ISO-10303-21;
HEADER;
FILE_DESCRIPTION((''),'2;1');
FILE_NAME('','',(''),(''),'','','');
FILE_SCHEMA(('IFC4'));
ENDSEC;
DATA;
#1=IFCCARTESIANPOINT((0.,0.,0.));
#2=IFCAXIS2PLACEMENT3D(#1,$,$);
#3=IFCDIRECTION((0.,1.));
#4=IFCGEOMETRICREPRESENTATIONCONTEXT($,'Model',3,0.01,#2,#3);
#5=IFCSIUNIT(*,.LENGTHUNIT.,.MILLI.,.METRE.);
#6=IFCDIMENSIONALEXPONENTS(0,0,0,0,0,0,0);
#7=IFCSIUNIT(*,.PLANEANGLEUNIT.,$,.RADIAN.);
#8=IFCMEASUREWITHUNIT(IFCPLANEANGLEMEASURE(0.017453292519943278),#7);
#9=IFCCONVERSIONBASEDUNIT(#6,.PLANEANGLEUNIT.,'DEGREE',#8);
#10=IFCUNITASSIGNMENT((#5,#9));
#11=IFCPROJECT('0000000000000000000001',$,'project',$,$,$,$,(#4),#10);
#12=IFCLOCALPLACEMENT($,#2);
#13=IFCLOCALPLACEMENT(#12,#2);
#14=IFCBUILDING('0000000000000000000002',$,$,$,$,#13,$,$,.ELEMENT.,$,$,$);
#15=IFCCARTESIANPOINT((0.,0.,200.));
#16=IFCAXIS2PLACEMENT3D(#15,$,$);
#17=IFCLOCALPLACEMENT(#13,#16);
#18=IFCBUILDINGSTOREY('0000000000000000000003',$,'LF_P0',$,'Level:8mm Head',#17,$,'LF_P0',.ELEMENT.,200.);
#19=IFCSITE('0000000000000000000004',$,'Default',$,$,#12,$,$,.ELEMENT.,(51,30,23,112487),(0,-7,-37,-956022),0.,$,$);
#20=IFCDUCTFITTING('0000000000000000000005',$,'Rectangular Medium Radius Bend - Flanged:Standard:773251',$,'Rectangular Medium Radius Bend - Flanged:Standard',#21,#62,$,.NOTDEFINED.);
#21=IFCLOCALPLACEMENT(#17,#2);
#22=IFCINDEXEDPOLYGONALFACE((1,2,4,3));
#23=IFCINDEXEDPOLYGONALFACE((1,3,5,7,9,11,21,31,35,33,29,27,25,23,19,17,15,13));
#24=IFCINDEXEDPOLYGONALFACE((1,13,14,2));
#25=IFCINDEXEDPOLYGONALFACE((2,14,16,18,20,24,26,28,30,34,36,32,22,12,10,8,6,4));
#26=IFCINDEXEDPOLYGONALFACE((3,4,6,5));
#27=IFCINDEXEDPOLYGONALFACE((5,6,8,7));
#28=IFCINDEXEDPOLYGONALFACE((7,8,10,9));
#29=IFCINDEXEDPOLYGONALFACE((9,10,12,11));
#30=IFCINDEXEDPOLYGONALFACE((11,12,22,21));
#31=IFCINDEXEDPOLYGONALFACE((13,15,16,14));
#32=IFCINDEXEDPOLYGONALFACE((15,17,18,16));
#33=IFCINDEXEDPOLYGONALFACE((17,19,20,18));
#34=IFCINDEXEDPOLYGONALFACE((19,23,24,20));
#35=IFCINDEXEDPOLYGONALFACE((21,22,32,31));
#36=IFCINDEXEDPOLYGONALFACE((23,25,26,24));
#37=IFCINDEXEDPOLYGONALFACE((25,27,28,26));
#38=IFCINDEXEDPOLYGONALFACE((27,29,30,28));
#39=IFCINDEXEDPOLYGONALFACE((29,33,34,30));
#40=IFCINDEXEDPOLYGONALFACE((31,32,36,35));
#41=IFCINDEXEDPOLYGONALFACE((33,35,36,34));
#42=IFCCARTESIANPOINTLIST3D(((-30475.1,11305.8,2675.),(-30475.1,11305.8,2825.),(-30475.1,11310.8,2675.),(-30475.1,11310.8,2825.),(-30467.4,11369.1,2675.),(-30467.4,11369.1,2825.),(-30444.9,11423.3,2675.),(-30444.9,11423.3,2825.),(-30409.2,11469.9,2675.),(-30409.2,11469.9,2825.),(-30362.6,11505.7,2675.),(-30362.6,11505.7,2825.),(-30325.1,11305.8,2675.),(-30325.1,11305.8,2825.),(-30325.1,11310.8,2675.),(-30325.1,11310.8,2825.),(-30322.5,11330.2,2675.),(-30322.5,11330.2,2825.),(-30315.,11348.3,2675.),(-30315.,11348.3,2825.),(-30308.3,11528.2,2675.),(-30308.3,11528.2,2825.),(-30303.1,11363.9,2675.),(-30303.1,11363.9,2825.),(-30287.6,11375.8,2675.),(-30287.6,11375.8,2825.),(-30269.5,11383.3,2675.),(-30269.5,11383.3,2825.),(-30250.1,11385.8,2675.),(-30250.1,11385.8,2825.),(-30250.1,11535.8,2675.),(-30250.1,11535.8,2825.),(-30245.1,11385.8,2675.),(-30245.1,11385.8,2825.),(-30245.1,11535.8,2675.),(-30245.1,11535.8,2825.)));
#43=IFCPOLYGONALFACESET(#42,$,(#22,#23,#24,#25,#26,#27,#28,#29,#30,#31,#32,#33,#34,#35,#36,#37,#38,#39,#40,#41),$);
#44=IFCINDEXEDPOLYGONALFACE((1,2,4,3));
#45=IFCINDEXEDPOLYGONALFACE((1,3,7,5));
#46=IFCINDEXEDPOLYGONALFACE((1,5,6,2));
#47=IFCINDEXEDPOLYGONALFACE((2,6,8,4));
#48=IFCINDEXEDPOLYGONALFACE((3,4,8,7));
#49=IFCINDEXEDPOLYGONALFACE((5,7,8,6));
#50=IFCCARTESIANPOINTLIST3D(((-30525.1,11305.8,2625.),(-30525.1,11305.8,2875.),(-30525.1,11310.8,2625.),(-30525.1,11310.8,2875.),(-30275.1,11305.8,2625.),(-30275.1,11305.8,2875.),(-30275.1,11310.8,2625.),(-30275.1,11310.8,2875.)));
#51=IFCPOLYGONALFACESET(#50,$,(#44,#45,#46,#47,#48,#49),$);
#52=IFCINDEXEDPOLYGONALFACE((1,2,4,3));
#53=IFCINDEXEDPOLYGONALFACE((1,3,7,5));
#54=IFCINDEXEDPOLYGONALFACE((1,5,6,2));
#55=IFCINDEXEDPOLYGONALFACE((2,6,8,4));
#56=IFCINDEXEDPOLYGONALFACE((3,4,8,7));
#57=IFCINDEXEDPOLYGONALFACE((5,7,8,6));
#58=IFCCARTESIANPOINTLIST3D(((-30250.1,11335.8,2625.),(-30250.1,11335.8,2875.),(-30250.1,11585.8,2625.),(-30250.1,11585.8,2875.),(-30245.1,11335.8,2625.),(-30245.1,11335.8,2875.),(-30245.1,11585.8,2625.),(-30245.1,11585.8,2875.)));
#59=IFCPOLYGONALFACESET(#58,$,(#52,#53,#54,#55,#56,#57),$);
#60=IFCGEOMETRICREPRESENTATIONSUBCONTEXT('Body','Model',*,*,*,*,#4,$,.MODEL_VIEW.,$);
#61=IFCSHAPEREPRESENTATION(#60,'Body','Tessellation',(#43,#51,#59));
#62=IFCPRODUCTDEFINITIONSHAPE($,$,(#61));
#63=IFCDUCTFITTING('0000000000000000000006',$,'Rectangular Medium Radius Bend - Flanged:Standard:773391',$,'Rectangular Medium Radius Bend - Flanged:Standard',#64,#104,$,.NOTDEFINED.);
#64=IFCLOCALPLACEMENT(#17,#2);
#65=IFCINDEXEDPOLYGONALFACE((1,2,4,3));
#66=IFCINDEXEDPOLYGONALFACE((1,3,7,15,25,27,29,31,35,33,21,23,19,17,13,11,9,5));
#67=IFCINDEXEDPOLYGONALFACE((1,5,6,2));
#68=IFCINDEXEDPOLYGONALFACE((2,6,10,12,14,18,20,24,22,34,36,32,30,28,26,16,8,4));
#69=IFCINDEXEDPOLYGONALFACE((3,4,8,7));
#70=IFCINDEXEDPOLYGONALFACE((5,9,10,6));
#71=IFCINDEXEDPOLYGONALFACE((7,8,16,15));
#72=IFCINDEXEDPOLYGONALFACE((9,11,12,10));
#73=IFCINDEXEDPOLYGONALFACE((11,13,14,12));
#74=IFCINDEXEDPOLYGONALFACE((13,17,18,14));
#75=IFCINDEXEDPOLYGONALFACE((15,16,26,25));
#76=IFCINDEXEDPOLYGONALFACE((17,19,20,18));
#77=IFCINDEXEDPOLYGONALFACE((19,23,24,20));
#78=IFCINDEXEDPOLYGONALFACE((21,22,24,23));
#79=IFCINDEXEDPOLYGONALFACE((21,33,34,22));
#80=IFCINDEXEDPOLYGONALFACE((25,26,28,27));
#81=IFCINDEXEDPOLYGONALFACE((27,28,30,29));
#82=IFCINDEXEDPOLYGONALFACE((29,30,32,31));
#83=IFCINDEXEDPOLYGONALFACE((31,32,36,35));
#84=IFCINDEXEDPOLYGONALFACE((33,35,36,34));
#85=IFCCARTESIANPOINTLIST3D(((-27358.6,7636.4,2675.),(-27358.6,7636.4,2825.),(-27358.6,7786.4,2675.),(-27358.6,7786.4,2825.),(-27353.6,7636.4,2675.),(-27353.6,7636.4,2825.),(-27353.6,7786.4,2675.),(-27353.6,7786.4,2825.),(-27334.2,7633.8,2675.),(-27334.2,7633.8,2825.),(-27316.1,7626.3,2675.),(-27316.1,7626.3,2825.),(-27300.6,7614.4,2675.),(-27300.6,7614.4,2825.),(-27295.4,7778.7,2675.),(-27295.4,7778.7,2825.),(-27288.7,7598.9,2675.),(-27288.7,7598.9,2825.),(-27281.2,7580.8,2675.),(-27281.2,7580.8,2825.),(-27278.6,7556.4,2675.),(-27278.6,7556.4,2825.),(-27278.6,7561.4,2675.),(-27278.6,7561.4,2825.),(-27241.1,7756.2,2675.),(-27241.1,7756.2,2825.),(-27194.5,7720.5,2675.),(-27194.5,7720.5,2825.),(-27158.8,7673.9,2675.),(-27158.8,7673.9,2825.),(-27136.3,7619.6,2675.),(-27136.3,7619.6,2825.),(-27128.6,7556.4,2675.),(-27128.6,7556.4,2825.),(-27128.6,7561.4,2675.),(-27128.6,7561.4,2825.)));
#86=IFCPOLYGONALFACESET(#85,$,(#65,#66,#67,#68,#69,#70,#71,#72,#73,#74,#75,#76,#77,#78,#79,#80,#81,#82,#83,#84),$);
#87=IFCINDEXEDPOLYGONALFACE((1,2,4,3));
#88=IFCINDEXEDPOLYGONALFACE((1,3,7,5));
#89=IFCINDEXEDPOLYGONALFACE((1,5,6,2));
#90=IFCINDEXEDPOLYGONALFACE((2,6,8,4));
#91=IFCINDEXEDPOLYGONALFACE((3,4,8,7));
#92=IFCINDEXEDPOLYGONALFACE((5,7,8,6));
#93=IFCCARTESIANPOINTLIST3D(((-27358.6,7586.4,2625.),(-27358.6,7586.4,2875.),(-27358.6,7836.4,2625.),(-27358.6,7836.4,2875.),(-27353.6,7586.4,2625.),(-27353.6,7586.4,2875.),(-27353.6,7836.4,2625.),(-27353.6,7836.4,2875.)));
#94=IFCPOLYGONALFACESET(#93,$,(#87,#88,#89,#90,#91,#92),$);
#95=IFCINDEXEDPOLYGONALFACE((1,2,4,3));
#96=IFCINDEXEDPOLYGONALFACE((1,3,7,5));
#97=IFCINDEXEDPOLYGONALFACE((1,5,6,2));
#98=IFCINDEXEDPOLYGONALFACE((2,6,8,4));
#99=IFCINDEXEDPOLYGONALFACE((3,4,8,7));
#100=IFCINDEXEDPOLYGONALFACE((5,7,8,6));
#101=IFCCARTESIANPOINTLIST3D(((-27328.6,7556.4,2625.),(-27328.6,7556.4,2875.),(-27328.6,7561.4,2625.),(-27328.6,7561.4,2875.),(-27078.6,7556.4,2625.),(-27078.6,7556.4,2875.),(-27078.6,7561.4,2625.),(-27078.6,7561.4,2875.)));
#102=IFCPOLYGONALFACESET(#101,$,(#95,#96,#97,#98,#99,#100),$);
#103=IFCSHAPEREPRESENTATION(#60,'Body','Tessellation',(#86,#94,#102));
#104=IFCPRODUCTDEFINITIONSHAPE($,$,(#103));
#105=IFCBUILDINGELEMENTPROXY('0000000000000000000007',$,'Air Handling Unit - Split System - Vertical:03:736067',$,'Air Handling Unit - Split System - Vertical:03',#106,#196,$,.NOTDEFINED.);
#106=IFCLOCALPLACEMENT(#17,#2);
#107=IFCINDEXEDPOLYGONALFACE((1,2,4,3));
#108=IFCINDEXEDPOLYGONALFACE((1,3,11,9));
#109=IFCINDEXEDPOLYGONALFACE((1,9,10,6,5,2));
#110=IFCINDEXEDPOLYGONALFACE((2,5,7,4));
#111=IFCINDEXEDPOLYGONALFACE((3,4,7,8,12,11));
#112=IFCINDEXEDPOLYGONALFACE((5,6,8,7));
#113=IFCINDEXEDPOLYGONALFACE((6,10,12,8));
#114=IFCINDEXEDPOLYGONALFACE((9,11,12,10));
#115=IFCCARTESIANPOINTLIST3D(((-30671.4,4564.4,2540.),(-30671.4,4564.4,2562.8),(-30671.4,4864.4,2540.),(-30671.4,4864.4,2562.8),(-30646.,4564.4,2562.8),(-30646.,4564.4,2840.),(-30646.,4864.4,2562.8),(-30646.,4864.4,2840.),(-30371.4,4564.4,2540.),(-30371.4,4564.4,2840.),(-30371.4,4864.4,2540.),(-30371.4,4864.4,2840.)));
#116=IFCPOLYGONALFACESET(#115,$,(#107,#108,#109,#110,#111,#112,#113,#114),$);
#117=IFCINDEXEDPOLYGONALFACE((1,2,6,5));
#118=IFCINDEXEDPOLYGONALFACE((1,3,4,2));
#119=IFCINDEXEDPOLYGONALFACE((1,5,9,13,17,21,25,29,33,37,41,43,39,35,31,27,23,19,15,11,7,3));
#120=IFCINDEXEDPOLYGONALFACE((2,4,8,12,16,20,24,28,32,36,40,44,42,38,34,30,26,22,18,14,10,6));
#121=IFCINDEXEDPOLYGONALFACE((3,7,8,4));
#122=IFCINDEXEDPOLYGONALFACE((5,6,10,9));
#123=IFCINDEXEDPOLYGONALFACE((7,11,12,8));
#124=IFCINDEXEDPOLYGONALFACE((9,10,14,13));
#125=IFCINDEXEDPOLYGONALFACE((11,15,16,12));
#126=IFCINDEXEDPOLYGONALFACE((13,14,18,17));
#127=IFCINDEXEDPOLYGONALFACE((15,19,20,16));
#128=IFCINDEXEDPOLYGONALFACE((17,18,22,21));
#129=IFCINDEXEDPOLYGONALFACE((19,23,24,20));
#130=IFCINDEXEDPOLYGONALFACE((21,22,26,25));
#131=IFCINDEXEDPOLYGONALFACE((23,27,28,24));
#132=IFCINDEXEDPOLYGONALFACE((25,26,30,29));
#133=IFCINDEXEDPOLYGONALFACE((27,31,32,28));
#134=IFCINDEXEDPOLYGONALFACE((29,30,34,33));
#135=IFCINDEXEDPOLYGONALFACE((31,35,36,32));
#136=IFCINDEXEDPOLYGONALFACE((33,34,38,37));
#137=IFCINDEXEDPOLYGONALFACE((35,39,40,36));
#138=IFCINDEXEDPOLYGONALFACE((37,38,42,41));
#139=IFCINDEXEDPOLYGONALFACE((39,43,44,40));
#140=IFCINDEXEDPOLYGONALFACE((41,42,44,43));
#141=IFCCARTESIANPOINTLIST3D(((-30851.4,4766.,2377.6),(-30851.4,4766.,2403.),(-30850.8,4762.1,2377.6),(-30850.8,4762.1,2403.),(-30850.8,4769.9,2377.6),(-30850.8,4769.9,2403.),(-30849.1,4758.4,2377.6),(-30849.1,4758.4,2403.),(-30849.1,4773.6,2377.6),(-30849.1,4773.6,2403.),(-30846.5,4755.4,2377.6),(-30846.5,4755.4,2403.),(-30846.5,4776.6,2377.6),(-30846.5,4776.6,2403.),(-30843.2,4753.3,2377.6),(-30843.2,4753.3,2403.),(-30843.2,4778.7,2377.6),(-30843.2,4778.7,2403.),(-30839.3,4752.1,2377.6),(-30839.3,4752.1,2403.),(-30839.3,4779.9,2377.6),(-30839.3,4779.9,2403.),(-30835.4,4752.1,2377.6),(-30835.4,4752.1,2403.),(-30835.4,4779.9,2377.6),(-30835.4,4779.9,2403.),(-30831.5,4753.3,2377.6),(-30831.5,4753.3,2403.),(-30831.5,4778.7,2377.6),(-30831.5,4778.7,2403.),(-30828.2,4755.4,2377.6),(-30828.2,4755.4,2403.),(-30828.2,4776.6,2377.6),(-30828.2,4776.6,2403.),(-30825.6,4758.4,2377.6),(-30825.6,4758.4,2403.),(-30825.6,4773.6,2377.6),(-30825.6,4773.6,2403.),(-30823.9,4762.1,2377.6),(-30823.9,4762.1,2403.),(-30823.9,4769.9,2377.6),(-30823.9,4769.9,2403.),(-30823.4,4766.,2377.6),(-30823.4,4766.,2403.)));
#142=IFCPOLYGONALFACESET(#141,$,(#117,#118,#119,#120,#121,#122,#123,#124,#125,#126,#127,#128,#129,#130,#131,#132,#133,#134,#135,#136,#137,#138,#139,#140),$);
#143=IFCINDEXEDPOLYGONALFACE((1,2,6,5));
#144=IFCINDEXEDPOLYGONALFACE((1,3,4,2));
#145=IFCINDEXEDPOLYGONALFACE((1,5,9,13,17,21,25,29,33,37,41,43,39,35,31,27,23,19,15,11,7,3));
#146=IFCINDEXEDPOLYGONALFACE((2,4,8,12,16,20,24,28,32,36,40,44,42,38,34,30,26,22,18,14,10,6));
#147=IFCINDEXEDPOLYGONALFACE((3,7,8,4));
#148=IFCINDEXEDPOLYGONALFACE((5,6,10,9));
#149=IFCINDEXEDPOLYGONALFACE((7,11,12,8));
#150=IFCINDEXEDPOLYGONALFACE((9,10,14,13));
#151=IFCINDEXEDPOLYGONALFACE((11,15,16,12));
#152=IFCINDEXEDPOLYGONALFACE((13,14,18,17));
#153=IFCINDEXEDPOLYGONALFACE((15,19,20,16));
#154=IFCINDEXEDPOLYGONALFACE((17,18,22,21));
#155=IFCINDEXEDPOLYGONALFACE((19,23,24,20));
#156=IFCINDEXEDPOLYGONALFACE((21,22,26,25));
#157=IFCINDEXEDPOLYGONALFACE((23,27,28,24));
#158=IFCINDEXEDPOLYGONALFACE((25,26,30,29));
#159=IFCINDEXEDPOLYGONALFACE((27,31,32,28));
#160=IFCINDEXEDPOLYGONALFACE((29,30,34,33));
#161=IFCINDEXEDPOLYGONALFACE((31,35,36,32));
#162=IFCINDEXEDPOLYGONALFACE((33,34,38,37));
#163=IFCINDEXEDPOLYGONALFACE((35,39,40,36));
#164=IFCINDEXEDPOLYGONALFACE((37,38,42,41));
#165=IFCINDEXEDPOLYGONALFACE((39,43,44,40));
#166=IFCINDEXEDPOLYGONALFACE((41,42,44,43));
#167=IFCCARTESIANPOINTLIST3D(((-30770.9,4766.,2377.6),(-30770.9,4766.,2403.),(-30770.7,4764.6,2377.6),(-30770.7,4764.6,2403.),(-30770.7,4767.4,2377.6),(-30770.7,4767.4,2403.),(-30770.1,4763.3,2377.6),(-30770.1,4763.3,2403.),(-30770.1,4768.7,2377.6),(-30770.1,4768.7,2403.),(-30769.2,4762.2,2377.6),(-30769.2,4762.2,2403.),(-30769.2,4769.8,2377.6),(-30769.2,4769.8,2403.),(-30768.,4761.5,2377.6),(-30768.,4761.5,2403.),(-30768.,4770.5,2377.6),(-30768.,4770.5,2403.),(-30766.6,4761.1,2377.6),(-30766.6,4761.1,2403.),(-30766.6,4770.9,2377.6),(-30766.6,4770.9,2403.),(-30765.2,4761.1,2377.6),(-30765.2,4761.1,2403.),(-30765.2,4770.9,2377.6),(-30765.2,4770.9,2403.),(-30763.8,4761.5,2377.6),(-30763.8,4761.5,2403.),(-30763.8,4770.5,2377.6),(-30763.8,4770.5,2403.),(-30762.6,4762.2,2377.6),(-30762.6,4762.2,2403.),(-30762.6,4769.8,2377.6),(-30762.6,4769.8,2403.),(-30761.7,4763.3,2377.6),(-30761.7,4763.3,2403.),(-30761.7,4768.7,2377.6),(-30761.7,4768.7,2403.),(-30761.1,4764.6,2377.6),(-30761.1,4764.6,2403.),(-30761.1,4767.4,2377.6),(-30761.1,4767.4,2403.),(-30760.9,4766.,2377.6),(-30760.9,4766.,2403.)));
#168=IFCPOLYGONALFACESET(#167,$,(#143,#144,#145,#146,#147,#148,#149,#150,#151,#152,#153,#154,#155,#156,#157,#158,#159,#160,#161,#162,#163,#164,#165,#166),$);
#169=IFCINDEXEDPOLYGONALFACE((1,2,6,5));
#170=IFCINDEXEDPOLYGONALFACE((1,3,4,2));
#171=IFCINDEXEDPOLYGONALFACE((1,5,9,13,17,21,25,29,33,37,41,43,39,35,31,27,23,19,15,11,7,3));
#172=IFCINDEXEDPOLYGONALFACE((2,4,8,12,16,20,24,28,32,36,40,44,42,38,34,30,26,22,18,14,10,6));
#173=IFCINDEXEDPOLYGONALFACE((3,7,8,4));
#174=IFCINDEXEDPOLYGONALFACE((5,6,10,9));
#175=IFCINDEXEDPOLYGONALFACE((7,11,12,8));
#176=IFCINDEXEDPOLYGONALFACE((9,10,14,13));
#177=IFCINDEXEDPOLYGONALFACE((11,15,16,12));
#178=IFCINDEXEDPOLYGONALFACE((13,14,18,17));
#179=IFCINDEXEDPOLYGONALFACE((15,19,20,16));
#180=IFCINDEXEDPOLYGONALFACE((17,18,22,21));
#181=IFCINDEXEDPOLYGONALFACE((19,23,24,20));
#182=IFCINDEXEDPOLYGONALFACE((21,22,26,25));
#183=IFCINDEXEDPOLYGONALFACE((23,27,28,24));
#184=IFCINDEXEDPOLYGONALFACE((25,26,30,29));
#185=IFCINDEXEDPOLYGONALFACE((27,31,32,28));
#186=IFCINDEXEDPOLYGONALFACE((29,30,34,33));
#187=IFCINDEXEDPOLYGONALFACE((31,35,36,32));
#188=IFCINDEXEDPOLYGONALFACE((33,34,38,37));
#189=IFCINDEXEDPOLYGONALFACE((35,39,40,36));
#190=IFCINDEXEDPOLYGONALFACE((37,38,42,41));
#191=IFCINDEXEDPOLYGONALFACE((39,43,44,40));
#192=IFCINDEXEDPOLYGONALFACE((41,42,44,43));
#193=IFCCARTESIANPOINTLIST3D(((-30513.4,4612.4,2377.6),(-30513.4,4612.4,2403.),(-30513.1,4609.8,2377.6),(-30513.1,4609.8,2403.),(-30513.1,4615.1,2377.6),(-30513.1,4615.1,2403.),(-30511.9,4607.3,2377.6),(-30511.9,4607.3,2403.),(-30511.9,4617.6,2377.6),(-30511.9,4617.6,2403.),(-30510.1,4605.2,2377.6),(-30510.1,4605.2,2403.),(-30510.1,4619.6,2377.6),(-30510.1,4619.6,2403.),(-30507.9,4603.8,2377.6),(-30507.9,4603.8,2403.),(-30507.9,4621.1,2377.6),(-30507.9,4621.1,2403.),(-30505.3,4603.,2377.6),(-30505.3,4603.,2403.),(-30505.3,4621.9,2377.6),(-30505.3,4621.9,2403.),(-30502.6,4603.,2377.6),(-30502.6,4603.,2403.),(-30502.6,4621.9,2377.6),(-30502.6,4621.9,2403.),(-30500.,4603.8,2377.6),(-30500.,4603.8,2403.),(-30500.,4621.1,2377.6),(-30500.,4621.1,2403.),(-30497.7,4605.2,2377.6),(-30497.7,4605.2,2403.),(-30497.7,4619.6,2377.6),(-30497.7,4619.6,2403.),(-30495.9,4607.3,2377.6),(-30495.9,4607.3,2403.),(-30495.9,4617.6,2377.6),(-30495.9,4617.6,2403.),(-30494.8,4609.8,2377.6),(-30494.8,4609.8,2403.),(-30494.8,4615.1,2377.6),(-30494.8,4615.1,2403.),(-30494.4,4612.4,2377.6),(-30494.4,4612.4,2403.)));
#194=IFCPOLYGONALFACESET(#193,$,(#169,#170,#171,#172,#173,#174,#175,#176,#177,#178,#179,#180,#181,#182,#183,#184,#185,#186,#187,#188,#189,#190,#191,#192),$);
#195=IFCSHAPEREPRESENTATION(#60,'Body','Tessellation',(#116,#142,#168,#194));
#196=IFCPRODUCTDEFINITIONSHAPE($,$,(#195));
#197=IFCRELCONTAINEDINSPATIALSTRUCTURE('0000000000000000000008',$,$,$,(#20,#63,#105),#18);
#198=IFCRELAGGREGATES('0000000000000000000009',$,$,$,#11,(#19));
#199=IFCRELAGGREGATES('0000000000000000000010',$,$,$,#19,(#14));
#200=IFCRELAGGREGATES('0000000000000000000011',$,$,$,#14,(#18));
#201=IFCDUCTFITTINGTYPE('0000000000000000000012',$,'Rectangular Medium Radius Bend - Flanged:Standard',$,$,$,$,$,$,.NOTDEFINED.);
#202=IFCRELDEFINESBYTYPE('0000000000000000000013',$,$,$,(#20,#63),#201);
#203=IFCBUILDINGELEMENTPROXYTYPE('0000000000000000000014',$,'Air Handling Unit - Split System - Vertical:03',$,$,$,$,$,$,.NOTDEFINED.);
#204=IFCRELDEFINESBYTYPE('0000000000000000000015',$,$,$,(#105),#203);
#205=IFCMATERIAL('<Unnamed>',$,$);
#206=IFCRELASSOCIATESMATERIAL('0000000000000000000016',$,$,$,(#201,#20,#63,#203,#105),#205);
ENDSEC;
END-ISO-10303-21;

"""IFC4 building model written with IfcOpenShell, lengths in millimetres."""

from ifc_helpers import new_model, entity, si_unit, converted_unit, direction, frame, origin, place, context, subcontext, project, spatial, line, arc, indexed_curve, outline, extrude, source, transform, mapped, material, type_object, type_shapes, element, save


model = new_model("IFC4")

# Units and contexts
model_context = context("Model", 3, precision=0.01, world=origin(), true_north=direction((0.0, 1.0)))
body_context = subcontext(model_context, "Body", "Model", "MODEL_VIEW")
ifc_project = project(units=[si_unit("LENGTHUNIT", "METRE", prefix="MILLI"), converted_unit("PLANEANGLEUNIT", "DEGREE", entity("IfcPlaneAngleMeasure", 0.017453292519943278), si_unit("PLANEANGLEUNIT", "RADIAN"), dimensions=[0, 0, 0, 0, 0, 0, 0])], contexts=[model_context])

# Site, building, storey
site_placement = place(None, origin())
site = spatial("IfcSite", under=ifc_project, at=site_placement, Name="Default", CompositionType="ELEMENT", RefLatitude=(51, 30, 23, 112487), RefLongitude=(0, -7, -37, -956022), RefElevation=0.0)
building_placement = place(site_placement, origin())
building = spatial("IfcBuilding", under=site, at=building_placement, CompositionType="ELEMENT")
storey_placement = place(building_placement, frame((0.0, 0.0, 200.0)))
storey = spatial("IfcBuildingStorey", under=building, at=storey_placement, Name="LF_P0", ObjectType="Level:8mm Head", LongName="LF_P0", CompositionType="ELEMENT", Elevation=200.0)

# Duct fittings
ifc_material = material(Name="<Unnamed>")
duct_fitting_type = type_object("IfcDuctFittingType", Name="Rectangular Medium Radius Bend - Flanged:Standard", PredefinedType="NOTDEFINED", material=ifc_material)
shared_shape_1 = source(origin(), body_context, "Body", "SweptSolid", [
    extrude(outline(indexed_curve([(-78.8, -151.2), (-73.7, -151.2), (85.3, -85.3), (151.3, 73.7), (151.3, 78.7), (1.3, 78.7), (1.3, 73.8), (-20.7, 20.7), (-73.7, -1.2), (-78.8, -1.2)], segments=[line(1, 2), arc(2, 3, 4), line(4, 5, 6, 7), arc(7, 8, 9), line(9, 10, 1)], self_intersect=False)), frame((-76.2, 76.2, -75.0)), (0.0, 0.0, 1.0), 150.0),
    extrude(outline(indexed_curve([(-2.5, -125.0), (2.5, -125.0), (2.5, 125.0), (-2.5, 125.0), (-2.5, -125.0)], self_intersect=False)), frame((0.0, 152.5, -125.0), z_axis=(0.0, 0.0, 1.0), x_axis=(0.0, 1.0, 0.0)), (0.0, 0.0, 1.0), 250.0),
    extrude(outline(indexed_curve([(-2.5, -125.0), (2.5, -125.0), (2.5, 125.0), (-2.5, 125.0), (-2.5, -125.0)], self_intersect=False)), frame((-152.5, 0.0, -125.0)), (0.0, 0.0, 1.0), 250.0),
])
type_shapes(duct_fitting_type, [shared_shape_1])
for number, where, z_axis, x_axis, name in (
    (1, (-30400.1, 11460.8, 2750.0), (0.0, 0.0, 1.0), (-1.0, 0.0, 0.0), "Rectangular Medium Radius Bend - Flanged:Standard:773251"),
    (2, (-27203.6, 7711.4, 2750.0), (0.0, 0.0, 1.0), (0.0, 1.0, 0.0), "Rectangular Medium Radius Bend - Flanged:Standard:773391"),
):
    element("IfcDuctFitting", number, at=place(storey_placement, frame(where, z_axis=z_axis, x_axis=x_axis)), inside=storey, type_object=duct_fitting_type, material=ifc_material, Name=name, ObjectType="Rectangular Medium Radius Bend - Flanged:Standard", PredefinedType="NOTDEFINED", context=body_context, shape_type="MappedRepresentation", body=[
        mapped(shared_shape_1, transform((0.0, 0.0, 0.0), scale=1.0)),
    ])

# Building element proxy
building_element_proxy_type_1 = type_object("IfcBuildingElementProxyType", Name="Air Handling Unit - Split System - Vertical:03", PredefinedType="NOTDEFINED", material=ifc_material)
shared_shape_2 = source(origin(), body_context, "Body", "SweptSolid", [
    extrude(outline(indexed_curve([(-191.5, -107.6), (108.5, -107.6), (108.5, -84.8), (83.1, -84.8), (83.1, 192.4), (-191.5, 192.4), (-191.5, -107.6)], self_intersect=False)), frame((-150.0, 42.4, 191.5), z_axis=(1.0, 0.0, 0.0), x_axis=(0.0, 0.0, 1.0)), (0.0, 0.0, 1.0), 300.0),
    extrude(outline(indexed_curve([(-14.0, 0.0), (0.0, -14.0), (14.0, 0.0), (0.0, 14.0)], segments=[arc(1, 2, 3), arc(3, 4, 1)], self_intersect=False)), frame((51.6, 287.0, 466.0), z_axis=(0.0, 1.0, 0.0), x_axis=(0.0, 0.0, -1.0)), (0.0, 0.0, 1.0), 25.4),
    extrude(outline(indexed_curve([(-5.0, 0.0), (0.0, -5.0), (5.0, 0.0), (0.0, 5.0)], segments=[arc(1, 2, 3), arc(3, 4, 1)], self_intersect=False)), frame((51.6, 287.0, 394.6), z_axis=(0.0, 1.0, 0.0), x_axis=(0.0, 0.0, -1.0)), (0.0, 0.0, 1.0), 25.4),
    extrude(outline(indexed_curve([(-9.5, 0.0), (0.0, -9.5), (9.5, 0.0), (0.0, 9.5)], segments=[arc(1, 2, 3), arc(3, 4, 1)], self_intersect=False)), frame((-102.0, 287.0, 132.6), z_axis=(0.0, 1.0, 0.0), x_axis=(0.0, 0.0, -1.0)), (0.0, 0.0, 1.0), 25.4),
])
type_shapes(building_element_proxy_type_1, [shared_shape_2])
for number, where, z_axis, x_axis, name in (
    (3, (-30371.4, 4714.4, 2690.0), (-1.0, 0.0, 0.0), (0.0, 1.0, 0.0), "Air Handling Unit - Split System - Vertical:03:736067"),
):
    element("IfcBuildingElementProxy", number, at=place(storey_placement, frame(where, z_axis=z_axis, x_axis=x_axis)), inside=storey, type_object=building_element_proxy_type_1, material=ifc_material, Name=name, ObjectType="Air Handling Unit - Split System - Vertical:03", PredefinedType="NOTDEFINED", context=body_context, shape_type="MappedRepresentation", body=[
        mapped(shared_shape_2, transform((0.0, 0.0, 0.0), scale=1.0)),
    ])

save(model, "model.ifc")
